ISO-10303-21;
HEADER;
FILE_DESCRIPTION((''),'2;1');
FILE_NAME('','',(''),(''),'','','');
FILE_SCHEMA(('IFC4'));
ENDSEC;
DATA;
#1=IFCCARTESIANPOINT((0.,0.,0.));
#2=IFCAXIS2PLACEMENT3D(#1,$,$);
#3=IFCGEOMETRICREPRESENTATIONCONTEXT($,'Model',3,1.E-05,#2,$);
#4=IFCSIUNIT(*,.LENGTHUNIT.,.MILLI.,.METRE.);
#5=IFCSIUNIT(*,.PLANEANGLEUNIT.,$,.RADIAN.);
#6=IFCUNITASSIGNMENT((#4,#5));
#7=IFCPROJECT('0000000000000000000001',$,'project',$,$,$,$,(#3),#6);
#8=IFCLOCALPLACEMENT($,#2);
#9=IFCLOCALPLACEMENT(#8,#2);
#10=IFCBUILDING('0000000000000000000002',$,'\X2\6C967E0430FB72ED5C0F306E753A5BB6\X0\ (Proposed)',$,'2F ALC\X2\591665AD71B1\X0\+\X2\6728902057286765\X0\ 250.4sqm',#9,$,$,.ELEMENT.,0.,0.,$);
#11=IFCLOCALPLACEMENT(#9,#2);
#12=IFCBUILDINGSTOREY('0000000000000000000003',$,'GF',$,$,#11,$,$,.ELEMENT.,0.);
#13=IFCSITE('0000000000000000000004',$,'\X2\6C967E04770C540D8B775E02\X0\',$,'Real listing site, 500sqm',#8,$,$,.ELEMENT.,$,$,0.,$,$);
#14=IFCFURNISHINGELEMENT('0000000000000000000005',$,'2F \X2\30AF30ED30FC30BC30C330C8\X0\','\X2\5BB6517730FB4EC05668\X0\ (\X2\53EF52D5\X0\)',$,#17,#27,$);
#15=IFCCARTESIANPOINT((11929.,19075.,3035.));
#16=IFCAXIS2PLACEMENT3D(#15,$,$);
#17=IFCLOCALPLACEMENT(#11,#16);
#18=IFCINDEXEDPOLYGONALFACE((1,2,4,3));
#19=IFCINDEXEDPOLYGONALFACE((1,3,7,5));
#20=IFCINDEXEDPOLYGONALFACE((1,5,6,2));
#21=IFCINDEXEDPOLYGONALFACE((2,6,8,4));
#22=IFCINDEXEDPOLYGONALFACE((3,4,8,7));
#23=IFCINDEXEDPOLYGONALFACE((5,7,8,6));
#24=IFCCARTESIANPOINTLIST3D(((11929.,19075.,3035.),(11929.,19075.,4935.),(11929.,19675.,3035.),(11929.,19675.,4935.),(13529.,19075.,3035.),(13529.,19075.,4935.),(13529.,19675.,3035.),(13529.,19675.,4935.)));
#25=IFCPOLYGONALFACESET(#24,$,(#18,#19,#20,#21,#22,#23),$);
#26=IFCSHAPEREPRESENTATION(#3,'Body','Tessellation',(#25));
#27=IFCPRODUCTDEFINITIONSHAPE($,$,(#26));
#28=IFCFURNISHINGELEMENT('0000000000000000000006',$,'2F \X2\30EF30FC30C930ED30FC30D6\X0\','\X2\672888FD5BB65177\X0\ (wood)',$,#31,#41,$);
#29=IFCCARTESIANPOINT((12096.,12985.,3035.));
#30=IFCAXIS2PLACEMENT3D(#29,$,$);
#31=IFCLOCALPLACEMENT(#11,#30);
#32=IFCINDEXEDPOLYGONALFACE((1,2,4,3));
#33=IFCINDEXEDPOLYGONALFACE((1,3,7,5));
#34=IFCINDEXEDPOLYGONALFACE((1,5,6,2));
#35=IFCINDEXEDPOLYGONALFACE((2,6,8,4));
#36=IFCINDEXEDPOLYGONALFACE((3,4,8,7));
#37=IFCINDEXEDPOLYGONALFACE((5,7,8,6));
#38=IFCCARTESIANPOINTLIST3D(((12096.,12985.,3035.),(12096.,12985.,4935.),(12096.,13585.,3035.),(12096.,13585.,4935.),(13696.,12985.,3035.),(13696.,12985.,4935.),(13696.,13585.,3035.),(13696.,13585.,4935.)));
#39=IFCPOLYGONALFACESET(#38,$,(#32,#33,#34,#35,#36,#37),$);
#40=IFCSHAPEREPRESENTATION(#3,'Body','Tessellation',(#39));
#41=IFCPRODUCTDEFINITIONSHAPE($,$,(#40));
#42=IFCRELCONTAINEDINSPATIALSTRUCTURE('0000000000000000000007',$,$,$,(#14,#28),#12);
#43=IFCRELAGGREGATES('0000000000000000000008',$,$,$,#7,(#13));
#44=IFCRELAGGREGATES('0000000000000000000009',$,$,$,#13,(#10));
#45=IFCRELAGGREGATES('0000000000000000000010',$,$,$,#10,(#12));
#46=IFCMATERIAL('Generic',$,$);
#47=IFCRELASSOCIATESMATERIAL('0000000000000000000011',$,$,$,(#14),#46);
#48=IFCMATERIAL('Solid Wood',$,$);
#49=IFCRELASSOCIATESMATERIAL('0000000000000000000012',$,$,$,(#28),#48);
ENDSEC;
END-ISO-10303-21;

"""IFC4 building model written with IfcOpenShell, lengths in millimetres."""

from ifc_helpers import new_model, si_unit, frame, frame_2d, origin, place, context, project, spatial, rectangle, extrude, material, element, save


model = new_model("IFC4")

# Units and contexts
model_context = context("Model", 3, precision=1e-05, world=origin())
ifc_project = project(units=[si_unit("LENGTHUNIT", "METRE", prefix="MILLI"), si_unit("PLANEANGLEUNIT", "RADIAN")], contexts=[model_context])

# Site, building, storey
site_placement = place(None, origin())
site = spatial("IfcSite", under=ifc_project, at=site_placement, Name="沖縄県名護市", ObjectType="Real listing site, 500sqm", CompositionType="ELEMENT", RefElevation=0.0)
building_placement = place(site_placement, origin())
building = spatial("IfcBuilding", under=site, at=building_placement, Name="沖縄・狭小の町家 (Proposed)", ObjectType="2F ALC外断熱+木造在来 250.4sqm", CompositionType="ELEMENT", ElevationOfRefHeight=0.0, ElevationOfTerrain=0.0)
storey_placement = place(building_placement, origin())
storey = spatial("IfcBuildingStorey", under=building, at=storey_placement, Name="GF", CompositionType="ELEMENT", Elevation=0.0)

# Shared definitions
ifc_material_1 = material(Name="Solid Wood")

# Shared definitions
ifc_material_2 = material(Name="Generic")

# Furnishing elements
furnishing_1_placement = place(storey_placement, frame((11929.0, 19075.0, 3035.0)))
element("IfcFurnishingElement", 1, at=furnishing_1_placement, inside=storey, material=ifc_material_2, Name="2F クローゼット", Description="家具・什器 (可動)", context=model_context, shape_type="SweptSolid", body=[
    extrude(rectangle(XDim=1600.0, YDim=600.0, at=frame_2d((800.0, 300.0))), frame((11929.0, 19075.0, 3035.0)), (0.0, 0.0, 1.0), 1900.0),
])
furnishing_2_placement = place(storey_placement, frame((12096.0, 12985.0, 3035.0)))
element("IfcFurnishingElement", 2, at=furnishing_2_placement, inside=storey, material=ifc_material_1, Name="2F ワードローブ", Description="木製家具 (wood)", context=model_context, shape_type="SweptSolid", body=[
    extrude(rectangle(XDim=1600.0, YDim=600.0, at=frame_2d((800.0, 300.0))), frame((12096.0, 12985.0, 3035.0)), (0.0, 0.0, 1.0), 1900.0),
])

save(model, "model.ifc")
